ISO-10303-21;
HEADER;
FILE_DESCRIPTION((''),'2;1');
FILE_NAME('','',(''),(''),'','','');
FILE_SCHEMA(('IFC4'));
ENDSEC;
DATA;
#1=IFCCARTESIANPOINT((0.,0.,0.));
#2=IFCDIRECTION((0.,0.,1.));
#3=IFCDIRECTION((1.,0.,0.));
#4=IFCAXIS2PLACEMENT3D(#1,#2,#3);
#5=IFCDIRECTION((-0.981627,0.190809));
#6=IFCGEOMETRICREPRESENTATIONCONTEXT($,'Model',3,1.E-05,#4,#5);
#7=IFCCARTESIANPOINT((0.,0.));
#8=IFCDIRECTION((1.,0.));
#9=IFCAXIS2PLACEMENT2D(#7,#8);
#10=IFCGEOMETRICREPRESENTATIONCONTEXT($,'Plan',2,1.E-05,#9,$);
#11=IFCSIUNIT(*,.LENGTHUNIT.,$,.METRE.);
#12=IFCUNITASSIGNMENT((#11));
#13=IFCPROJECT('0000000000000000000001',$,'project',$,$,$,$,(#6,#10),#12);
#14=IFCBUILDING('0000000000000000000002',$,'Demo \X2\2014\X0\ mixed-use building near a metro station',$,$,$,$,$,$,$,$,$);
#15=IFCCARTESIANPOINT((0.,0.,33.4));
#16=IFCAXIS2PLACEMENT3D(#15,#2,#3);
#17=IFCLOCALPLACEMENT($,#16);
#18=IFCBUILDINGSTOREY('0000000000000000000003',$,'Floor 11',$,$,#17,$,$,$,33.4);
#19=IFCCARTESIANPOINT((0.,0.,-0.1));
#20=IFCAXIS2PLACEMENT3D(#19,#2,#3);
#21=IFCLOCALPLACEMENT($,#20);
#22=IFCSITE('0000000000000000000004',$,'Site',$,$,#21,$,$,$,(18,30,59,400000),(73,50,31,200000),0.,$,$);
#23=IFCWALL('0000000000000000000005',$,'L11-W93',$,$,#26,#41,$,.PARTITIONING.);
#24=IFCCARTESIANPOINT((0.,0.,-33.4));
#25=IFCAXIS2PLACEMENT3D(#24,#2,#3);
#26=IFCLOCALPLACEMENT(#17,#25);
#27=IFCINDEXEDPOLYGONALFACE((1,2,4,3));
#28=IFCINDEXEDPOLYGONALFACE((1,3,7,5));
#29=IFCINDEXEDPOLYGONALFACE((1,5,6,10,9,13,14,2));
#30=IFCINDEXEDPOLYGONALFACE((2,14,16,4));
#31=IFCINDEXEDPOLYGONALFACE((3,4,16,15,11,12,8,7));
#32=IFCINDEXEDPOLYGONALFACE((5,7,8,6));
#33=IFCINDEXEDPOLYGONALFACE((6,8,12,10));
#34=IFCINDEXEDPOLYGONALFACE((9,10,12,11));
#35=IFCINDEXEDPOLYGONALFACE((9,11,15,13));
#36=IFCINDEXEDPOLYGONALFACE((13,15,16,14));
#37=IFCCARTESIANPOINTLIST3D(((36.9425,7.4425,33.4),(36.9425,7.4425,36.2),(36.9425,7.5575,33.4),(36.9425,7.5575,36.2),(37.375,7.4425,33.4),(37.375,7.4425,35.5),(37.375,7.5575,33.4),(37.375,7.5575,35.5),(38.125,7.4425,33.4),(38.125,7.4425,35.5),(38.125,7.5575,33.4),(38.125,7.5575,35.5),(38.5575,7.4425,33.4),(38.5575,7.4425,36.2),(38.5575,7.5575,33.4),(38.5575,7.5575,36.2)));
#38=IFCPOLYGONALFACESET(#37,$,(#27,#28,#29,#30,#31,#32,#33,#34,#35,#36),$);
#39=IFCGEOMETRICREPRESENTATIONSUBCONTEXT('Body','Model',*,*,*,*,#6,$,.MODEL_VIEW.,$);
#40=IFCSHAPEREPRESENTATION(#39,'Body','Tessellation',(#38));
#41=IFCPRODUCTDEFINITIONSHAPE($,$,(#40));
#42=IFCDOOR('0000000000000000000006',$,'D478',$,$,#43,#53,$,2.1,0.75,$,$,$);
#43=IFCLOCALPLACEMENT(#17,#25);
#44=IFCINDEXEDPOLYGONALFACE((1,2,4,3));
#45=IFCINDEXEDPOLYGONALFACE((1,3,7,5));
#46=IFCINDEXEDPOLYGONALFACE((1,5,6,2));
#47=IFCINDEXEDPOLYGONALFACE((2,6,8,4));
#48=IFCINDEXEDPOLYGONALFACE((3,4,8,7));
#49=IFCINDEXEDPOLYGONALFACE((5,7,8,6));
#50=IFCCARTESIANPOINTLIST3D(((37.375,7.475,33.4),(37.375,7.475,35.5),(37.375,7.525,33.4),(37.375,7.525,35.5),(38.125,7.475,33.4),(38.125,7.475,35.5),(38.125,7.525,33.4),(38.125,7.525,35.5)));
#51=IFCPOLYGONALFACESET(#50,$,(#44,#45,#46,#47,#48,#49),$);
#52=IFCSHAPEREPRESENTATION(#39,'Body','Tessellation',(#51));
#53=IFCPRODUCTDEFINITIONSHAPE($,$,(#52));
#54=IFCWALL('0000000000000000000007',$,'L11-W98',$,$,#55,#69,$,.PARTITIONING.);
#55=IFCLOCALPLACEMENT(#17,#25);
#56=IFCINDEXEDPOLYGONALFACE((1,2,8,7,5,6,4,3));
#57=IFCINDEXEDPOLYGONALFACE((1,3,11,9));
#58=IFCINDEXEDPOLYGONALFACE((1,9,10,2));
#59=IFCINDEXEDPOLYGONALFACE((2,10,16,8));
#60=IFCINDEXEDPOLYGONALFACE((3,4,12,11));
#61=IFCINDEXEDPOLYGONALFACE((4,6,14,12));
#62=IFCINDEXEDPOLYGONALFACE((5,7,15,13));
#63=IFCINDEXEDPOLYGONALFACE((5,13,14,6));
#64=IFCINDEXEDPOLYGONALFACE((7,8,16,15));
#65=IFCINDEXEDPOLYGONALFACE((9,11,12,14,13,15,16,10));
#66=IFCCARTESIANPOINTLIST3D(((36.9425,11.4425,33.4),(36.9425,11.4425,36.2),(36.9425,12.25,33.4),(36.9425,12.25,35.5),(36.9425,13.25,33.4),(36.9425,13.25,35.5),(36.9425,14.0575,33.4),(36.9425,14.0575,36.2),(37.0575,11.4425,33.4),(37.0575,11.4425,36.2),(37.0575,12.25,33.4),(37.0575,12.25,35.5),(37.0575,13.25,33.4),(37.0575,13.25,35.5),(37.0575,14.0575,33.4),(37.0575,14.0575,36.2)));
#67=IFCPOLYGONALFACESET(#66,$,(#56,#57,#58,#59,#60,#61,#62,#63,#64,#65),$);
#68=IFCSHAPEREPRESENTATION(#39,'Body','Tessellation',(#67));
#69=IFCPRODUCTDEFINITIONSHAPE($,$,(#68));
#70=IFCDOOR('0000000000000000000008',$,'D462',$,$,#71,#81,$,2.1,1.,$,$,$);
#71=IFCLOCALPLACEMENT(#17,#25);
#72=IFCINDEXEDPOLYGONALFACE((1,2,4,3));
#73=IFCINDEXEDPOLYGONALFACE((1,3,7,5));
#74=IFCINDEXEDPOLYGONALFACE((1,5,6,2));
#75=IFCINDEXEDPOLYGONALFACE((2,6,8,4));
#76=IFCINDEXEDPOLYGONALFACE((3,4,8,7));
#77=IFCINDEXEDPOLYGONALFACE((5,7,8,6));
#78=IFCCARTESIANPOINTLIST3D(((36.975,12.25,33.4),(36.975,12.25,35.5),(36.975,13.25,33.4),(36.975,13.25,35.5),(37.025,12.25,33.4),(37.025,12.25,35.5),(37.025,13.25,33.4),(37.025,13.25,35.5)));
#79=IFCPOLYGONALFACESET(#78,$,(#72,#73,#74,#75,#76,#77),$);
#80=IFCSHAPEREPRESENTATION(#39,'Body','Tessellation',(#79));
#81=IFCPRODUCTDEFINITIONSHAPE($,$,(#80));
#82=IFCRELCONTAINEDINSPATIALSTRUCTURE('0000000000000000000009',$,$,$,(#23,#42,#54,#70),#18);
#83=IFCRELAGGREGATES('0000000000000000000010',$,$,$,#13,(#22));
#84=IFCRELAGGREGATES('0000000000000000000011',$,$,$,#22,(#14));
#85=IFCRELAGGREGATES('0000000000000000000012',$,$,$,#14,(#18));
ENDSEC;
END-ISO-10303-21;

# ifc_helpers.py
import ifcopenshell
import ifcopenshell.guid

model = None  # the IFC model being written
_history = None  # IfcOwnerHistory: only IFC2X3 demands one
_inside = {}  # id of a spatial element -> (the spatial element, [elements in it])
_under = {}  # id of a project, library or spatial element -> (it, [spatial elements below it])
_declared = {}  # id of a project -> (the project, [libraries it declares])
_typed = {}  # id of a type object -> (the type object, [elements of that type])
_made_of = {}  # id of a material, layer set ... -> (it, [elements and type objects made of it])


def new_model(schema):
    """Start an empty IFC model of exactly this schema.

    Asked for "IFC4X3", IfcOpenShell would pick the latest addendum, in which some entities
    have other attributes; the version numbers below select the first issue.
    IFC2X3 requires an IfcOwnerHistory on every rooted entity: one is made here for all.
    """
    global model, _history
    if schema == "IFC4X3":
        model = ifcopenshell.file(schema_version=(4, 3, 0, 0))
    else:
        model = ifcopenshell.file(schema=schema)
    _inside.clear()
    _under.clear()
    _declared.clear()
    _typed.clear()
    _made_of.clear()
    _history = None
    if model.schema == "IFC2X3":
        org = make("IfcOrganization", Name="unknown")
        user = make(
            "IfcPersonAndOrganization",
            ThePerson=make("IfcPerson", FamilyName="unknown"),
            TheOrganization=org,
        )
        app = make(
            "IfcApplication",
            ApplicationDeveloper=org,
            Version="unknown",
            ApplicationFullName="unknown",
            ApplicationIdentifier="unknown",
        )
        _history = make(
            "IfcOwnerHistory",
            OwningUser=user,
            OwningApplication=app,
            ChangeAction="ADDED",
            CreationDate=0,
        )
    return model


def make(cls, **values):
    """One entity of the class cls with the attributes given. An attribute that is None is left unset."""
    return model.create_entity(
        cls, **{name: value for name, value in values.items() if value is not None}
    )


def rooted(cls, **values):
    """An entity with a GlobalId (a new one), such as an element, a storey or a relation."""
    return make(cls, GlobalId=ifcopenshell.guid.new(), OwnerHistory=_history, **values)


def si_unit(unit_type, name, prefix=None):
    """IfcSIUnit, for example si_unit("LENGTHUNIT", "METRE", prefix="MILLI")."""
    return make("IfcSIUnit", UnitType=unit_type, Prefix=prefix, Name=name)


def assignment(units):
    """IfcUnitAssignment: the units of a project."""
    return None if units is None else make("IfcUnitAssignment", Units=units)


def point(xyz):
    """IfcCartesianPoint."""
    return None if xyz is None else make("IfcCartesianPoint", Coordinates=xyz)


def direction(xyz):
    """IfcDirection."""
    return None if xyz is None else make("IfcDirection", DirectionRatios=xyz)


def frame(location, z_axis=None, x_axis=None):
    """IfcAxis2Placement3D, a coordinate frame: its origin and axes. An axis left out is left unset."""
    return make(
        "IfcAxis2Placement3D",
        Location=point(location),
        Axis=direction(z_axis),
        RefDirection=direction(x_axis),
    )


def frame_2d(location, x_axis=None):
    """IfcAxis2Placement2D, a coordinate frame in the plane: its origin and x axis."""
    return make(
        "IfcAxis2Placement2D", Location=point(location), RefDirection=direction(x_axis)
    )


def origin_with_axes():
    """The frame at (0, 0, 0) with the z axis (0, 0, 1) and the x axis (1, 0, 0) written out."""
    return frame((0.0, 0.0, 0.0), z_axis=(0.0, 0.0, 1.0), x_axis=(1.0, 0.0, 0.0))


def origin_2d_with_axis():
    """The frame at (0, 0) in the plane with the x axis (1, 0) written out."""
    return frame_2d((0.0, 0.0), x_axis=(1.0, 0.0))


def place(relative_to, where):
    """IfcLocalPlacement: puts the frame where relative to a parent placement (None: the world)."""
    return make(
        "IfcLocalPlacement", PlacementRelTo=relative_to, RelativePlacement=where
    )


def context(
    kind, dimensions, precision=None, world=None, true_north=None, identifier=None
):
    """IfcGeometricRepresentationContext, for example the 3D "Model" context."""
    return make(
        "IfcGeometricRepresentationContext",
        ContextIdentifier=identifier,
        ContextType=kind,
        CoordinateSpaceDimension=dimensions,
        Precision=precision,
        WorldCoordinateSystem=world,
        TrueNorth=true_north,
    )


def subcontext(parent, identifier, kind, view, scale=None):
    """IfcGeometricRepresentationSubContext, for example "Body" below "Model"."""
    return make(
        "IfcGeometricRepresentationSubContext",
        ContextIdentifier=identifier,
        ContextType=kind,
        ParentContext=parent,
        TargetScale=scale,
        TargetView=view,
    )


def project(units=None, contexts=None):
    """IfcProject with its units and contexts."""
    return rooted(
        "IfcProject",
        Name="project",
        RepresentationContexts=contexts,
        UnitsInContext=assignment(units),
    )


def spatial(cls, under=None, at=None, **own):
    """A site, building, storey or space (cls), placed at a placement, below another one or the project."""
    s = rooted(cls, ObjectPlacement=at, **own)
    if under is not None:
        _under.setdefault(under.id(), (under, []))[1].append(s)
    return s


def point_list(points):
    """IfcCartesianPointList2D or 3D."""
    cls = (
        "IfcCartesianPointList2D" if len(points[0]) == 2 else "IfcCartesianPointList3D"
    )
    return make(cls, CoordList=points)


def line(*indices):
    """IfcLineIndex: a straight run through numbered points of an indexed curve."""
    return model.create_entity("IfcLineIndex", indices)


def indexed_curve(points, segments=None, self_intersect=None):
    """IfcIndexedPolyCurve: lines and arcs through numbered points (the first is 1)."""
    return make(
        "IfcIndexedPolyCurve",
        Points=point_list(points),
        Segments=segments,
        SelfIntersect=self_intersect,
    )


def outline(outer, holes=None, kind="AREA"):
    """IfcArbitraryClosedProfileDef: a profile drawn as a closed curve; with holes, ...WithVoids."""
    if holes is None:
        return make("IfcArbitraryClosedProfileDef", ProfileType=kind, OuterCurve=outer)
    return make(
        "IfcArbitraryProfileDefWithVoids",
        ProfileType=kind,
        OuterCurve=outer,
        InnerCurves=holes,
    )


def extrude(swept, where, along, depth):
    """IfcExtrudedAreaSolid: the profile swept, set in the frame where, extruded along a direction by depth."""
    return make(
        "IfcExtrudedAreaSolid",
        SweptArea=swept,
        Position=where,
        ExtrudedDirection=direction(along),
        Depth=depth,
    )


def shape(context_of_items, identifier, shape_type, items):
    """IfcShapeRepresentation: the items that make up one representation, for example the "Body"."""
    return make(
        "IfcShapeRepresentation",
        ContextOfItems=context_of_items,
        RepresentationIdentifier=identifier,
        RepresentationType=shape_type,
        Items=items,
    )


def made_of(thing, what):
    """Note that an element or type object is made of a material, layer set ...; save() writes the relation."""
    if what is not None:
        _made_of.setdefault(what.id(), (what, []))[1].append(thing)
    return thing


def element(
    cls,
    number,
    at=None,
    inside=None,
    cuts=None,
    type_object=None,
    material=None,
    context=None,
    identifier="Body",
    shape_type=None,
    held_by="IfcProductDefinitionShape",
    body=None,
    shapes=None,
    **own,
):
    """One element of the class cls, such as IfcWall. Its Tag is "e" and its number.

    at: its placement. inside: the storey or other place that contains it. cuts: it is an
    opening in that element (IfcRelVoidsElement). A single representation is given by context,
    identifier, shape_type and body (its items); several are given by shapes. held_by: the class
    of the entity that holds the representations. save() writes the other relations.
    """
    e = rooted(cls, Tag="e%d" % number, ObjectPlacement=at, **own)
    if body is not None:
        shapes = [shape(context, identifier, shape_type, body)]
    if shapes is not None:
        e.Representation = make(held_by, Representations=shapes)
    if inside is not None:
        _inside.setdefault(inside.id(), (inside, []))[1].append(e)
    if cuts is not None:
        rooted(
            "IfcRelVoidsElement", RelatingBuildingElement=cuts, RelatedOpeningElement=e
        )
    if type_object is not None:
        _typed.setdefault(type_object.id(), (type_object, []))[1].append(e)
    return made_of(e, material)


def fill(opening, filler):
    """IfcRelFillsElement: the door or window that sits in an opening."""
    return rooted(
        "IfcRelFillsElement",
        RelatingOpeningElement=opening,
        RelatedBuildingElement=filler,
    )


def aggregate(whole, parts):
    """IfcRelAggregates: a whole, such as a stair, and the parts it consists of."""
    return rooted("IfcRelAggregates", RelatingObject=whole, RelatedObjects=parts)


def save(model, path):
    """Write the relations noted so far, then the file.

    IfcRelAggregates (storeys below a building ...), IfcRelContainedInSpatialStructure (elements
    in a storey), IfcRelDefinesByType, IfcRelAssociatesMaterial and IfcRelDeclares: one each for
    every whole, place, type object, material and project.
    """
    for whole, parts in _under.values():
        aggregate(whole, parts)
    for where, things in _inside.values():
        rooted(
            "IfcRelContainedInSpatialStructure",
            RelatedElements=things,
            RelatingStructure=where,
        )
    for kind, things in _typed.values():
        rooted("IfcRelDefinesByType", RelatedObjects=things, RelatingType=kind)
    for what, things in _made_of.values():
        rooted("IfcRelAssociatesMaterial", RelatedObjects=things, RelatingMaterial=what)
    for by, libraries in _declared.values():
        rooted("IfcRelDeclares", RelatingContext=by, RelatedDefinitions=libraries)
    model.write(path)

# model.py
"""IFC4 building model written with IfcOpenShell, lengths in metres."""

from ifc_helpers import new_model, si_unit, direction, frame, origin_with_axes, origin_2d_with_axis, place, context, subcontext, project, spatial, line, indexed_curve, outline, extrude, element, fill, save


model = new_model("IFC4")

# Units and contexts
model_context = context("Model", 3, precision=1e-05, world=origin_with_axes(), true_north=direction((-0.981627, 0.190809)))
plan_context = context("Plan", 2, precision=1e-05, world=origin_2d_with_axis())
body_context = subcontext(model_context, "Body", "Model", "MODEL_VIEW")
ifc_project = project(units=[si_unit("LENGTHUNIT", "METRE")], contexts=[model_context, plan_context])

# Site, building, storey
site_placement = place(None, frame((0.0, 0.0, -0.1), z_axis=(0.0, 0.0, 1.0), x_axis=(1.0, 0.0, 0.0)))
site = spatial("IfcSite", under=ifc_project, at=site_placement, Name="Site", RefLatitude=(18, 30, 59, 400000), RefLongitude=(73, 50, 31, 200000), RefElevation=0.0)
building = spatial("IfcBuilding", under=site, Name="Demo — mixed-use building near a metro station")
storey_placement = place(None, frame((0.0, 0.0, 33.4), z_axis=(0.0, 0.0, 1.0), x_axis=(1.0, 0.0, 0.0)))
storey = spatial("IfcBuildingStorey", under=building, at=storey_placement, Name="Floor 11", Elevation=33.4)

# Wall, opening, door
wall_1_placement = place(storey_placement, frame((0.0, 0.0, -33.4), z_axis=(0.0, 0.0, 1.0), x_axis=(1.0, 0.0, 0.0)))
wall_1 = element("IfcWall", 1, at=wall_1_placement, inside=storey, Name="L11-W93", PredefinedType="PARTITIONING", context=body_context, shape_type="SweptSolid", body=[
    extrude(outline(indexed_curve([(38.5575, 7.4425), (36.9425, 7.4425), (36.9425, 7.5575), (38.5575, 7.5575)], segments=[line(1, 2, 3, 4, 1)])), frame((0.0, 0.0, 33.4), z_axis=(0.0, 0.0, 1.0), x_axis=(1.0, 0.0, 0.0)), (0.0, 0.0, 1.0), 2.8),
])
opening_1_placement = place(wall_1_placement, origin_with_axes())
opening_1 = element("IfcOpeningElement", 2, at=opening_1_placement, cuts=wall_1, context=body_context, shape_type="SweptSolid", body=[
    extrude(outline(indexed_curve([(38.125, 7.3925), (37.375, 7.3925), (37.375, 7.6075), (38.125, 7.6075)], segments=[line(1, 2, 3, 4, 1)])), frame((0.0, 0.0, 33.4), z_axis=(0.0, 0.0, 1.0), x_axis=(1.0, 0.0, 0.0)), (0.0, 0.0, 1.0), 2.1),
])
door_1_placement = place(storey_placement, frame((0.0, 0.0, -33.4), z_axis=(0.0, 0.0, 1.0), x_axis=(1.0, 0.0, 0.0)))
door_1 = element("IfcDoor", 3, at=door_1_placement, inside=storey, Name="D478", OverallHeight=2.1, OverallWidth=0.75, context=body_context, shape_type="SweptSolid", body=[
    extrude(outline(indexed_curve([(38.125, 7.475), (37.375, 7.475), (37.375, 7.525), (38.125, 7.525)], segments=[line(1, 2, 3, 4, 1)])), frame((0.0, 0.0, 33.4), z_axis=(0.0, 0.0, 1.0), x_axis=(1.0, 0.0, 0.0)), (0.0, 0.0, 1.0), 2.1),
])
fill(opening_1, door_1)

# Wall, opening, door
wall_2_placement = place(storey_placement, frame((0.0, 0.0, -33.4), z_axis=(0.0, 0.0, 1.0), x_axis=(1.0, 0.0, 0.0)))
wall_2 = element("IfcWall", 4, at=wall_2_placement, inside=storey, Name="L11-W98", PredefinedType="PARTITIONING", context=body_context, shape_type="SweptSolid", body=[
    extrude(outline(indexed_curve([(36.9425, 11.4425), (36.9425, 14.0575), (37.0575, 14.0575), (37.0575, 11.4425)], segments=[line(1, 2, 3, 4, 1)])), frame((0.0, 0.0, 33.4), z_axis=(0.0, 0.0, 1.0), x_axis=(1.0, 0.0, 0.0)), (0.0, 0.0, 1.0), 2.8),
])
opening_2_placement = place(wall_2_placement, origin_with_axes())
opening_2 = element("IfcOpeningElement", 5, at=opening_2_placement, cuts=wall_2, context=body_context, shape_type="SweptSolid", body=[
    extrude(outline(indexed_curve([(36.8925, 12.25), (36.8925, 13.25), (37.1075, 13.25), (37.1075, 12.25)], segments=[line(1, 2, 3, 4, 1)])), frame((0.0, 0.0, 33.4), z_axis=(0.0, 0.0, 1.0), x_axis=(1.0, 0.0, 0.0)), (0.0, 0.0, 1.0), 2.1),
])
door_2_placement = place(storey_placement, frame((0.0, 0.0, -33.4), z_axis=(0.0, 0.0, 1.0), x_axis=(1.0, 0.0, 0.0)))
door_2 = element("IfcDoor", 6, at=door_2_placement, inside=storey, Name="D462", OverallHeight=2.1, OverallWidth=1.0, context=body_context, shape_type="SweptSolid", body=[
    extrude(outline(indexed_curve([(36.975, 12.25), (36.975, 13.25), (37.025, 13.25), (37.025, 12.25)], segments=[line(1, 2, 3, 4, 1)])), frame((0.0, 0.0, 33.4), z_axis=(0.0, 0.0, 1.0), x_axis=(1.0, 0.0, 0.0)), (0.0, 0.0, 1.0), 2.1),
])
fill(opening_2, door_2)

save(model, "model.ifc")
